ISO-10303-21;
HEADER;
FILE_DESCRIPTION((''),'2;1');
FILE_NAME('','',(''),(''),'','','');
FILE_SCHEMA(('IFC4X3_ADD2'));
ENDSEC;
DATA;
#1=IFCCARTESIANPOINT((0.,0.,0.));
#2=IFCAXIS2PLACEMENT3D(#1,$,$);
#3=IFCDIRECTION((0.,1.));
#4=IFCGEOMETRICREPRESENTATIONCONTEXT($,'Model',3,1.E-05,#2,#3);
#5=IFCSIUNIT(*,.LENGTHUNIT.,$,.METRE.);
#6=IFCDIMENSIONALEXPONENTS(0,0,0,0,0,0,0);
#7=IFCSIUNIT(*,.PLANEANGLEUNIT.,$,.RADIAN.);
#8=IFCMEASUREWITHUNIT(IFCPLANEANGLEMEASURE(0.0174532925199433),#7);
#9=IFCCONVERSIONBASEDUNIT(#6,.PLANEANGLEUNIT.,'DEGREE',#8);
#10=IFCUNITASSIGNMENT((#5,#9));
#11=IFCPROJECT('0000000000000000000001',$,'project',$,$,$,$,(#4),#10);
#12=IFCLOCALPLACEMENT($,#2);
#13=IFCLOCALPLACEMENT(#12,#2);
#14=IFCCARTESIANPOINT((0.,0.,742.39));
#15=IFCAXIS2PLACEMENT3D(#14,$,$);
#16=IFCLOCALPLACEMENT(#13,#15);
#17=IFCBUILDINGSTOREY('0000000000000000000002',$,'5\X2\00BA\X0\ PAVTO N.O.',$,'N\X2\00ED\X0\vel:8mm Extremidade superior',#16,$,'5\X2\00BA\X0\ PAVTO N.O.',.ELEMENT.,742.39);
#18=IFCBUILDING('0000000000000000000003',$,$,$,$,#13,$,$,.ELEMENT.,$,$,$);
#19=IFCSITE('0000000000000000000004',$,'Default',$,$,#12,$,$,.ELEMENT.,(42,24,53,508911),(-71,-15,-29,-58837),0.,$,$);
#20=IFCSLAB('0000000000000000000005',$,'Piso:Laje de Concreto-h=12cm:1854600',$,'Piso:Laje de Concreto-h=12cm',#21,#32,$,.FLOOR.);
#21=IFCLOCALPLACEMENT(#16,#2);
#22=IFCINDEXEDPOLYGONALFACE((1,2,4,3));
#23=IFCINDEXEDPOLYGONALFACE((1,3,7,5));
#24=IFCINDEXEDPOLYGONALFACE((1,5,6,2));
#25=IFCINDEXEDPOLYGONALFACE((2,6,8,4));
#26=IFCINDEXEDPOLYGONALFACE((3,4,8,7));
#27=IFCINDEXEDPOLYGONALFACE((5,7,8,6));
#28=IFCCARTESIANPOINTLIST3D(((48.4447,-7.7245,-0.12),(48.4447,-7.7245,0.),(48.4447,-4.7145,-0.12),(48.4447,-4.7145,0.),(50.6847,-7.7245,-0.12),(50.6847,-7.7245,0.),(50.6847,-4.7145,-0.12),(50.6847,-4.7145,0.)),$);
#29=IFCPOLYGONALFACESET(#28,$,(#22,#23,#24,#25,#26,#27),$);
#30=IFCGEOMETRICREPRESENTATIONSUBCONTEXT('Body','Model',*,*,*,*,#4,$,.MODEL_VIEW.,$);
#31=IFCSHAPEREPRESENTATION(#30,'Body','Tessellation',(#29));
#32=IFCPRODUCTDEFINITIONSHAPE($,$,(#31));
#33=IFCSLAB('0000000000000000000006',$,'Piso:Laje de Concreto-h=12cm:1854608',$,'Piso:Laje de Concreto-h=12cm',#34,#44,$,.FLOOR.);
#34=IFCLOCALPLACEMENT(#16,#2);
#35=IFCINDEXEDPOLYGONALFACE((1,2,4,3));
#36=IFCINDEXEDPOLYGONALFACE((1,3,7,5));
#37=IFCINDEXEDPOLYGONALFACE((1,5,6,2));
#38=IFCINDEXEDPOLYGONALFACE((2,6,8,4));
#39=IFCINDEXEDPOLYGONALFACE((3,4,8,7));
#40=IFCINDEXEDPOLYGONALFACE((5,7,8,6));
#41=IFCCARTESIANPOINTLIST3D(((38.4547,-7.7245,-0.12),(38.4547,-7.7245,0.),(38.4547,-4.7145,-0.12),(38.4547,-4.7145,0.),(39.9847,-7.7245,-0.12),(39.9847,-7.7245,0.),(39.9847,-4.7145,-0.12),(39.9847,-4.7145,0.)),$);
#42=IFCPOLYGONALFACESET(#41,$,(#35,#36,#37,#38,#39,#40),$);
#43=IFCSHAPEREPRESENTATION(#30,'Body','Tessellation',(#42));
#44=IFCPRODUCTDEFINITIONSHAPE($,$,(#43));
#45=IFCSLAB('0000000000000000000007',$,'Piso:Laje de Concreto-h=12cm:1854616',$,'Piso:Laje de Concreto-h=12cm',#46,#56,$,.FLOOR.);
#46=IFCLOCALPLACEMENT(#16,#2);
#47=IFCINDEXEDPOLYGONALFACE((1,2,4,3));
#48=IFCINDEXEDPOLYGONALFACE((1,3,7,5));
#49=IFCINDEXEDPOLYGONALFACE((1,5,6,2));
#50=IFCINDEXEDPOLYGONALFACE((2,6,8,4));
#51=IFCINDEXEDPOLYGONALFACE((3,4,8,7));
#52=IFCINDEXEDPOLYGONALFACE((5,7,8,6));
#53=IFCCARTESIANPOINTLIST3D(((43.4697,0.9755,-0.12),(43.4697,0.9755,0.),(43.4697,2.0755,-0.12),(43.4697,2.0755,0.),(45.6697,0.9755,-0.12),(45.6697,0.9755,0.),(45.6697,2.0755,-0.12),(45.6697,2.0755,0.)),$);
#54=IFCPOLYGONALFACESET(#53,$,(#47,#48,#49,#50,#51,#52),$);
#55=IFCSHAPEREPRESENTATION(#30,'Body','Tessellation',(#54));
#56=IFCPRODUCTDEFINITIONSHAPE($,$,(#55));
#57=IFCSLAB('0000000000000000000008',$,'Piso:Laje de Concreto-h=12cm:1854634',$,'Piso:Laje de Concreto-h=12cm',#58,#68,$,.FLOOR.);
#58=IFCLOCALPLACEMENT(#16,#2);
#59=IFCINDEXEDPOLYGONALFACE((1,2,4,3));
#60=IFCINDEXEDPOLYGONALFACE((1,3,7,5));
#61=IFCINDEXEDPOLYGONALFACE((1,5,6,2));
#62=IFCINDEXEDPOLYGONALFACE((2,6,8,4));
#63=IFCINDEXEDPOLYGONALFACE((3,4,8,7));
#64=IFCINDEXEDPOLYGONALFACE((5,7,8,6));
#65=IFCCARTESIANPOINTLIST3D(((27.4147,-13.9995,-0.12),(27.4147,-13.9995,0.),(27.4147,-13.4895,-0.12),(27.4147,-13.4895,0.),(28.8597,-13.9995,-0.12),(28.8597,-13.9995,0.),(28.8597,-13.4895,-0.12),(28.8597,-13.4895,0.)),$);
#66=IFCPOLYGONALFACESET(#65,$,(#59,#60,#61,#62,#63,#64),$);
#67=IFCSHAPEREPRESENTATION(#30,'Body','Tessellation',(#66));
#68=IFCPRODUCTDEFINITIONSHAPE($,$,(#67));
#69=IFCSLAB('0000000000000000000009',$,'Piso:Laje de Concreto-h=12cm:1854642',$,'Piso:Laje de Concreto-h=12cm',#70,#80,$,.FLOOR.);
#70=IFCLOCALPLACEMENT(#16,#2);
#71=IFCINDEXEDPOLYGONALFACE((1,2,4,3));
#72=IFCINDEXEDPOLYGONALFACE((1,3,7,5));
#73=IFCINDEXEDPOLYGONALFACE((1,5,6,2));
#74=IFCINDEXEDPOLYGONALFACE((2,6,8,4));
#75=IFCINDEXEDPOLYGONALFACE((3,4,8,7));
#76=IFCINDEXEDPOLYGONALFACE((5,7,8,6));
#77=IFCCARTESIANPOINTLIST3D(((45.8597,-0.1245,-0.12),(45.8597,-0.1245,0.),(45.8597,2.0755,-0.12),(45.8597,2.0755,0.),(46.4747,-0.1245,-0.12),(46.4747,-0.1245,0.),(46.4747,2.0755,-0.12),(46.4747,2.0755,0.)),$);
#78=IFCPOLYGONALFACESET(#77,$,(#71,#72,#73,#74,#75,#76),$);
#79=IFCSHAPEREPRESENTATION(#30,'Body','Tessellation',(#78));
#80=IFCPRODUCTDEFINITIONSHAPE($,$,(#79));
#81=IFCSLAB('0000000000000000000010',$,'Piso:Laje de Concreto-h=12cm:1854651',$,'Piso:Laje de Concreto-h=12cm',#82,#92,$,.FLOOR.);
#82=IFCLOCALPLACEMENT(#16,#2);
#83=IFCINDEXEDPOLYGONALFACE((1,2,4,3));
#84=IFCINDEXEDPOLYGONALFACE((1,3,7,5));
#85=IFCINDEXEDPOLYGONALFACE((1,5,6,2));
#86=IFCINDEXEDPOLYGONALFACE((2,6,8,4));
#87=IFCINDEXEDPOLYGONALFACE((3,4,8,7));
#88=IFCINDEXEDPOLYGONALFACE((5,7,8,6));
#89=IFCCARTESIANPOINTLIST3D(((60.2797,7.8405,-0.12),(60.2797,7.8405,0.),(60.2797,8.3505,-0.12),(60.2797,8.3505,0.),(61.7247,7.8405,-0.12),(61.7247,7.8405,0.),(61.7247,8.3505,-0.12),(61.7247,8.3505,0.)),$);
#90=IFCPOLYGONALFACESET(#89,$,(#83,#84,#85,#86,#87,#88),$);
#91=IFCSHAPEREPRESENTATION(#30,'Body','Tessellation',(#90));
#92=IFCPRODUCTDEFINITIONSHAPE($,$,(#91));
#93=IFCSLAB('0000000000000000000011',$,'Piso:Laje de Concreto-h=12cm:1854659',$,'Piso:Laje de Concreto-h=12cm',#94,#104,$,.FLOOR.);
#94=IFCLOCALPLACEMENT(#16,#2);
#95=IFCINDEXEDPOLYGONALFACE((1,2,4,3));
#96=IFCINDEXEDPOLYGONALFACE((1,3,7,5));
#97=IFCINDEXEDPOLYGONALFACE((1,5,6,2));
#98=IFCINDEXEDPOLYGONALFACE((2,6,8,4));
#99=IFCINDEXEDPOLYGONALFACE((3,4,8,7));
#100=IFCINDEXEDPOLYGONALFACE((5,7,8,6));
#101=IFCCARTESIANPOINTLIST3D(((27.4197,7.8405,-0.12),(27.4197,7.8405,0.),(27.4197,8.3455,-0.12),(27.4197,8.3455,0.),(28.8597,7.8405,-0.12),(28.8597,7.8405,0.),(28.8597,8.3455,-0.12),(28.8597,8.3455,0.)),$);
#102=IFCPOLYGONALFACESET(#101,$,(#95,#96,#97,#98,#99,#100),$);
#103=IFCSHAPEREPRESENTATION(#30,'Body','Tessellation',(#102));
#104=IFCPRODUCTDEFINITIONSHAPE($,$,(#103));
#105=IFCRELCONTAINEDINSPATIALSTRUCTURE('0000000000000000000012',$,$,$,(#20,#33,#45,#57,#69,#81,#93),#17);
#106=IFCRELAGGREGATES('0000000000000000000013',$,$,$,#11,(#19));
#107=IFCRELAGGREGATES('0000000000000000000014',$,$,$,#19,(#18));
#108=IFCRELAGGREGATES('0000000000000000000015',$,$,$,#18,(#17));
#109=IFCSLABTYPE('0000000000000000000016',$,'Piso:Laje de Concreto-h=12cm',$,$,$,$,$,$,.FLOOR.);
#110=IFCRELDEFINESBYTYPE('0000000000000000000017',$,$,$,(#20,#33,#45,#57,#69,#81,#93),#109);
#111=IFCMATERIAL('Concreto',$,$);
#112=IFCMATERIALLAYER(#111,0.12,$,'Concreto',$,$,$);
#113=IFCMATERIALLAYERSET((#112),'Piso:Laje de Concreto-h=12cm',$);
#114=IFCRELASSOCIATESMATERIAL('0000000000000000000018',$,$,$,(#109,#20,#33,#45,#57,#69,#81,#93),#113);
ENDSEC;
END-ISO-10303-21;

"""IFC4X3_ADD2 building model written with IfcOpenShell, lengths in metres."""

from ifc_helpers import new_model, entity, si_unit, converted_unit, direction, frame, frame_2d, origin, origin_2d_with_axis, place, context, subcontext, project, spatial, rectangle, extrude, material, layer, layer_set, layer_usage, type_object, element, save


model = new_model("IFC4X3_ADD2")

# Units and contexts
model_context = context("Model", 3, precision=1e-05, world=origin(), true_north=direction((0.0, 1.0)))
body_context = subcontext(model_context, "Body", "Model", "MODEL_VIEW")
ifc_project = project(units=[si_unit("LENGTHUNIT", "METRE"), converted_unit("PLANEANGLEUNIT", "DEGREE", entity("IfcPlaneAngleMeasure", 0.0174532925199433), si_unit("PLANEANGLEUNIT", "RADIAN"), dimensions=[0, 0, 0, 0, 0, 0, 0])], contexts=[model_context])

# Site, building, storey
site_placement = place(None, origin())
site = spatial("IfcSite", under=ifc_project, at=site_placement, Name="Default", CompositionType="ELEMENT", RefLatitude=(42, 24, 53, 508911), RefLongitude=(-71, -15, -29, -58837), RefElevation=0.0)
building_placement = place(site_placement, origin())
building = spatial("IfcBuilding", under=site, at=building_placement, CompositionType="ELEMENT")
storey_placement = place(building_placement, frame((0.0, 0.0, 742.39)))
storey = spatial("IfcBuildingStorey", under=building, at=storey_placement, Name="5º PAVTO N.O.", ObjectType="Nível:8mm Extremidade superior", LongName="5º PAVTO N.O.", CompositionType="ELEMENT", Elevation=742.39)

# Shared definitions
ifc_material = material(Name="Concreto")

# Shared definitions
ifc_layer_1 = layer(ifc_material, 0.12, Name="Concreto")
ifc_layer_set_1 = layer_set([ifc_layer_1], Name="Piso:Laje de Concreto-h=12cm")
slab_type_1 = type_object("IfcSlabType", Name="Piso:Laje de Concreto-h=12cm", PredefinedType="FLOOR", material=ifc_layer_set_1)

# Slabs
ifc_layer_usage_1 = layer_usage(ifc_layer_set_1, "AXIS3", "POSITIVE", 0.0)
slab_1_placement = place(storey_placement, origin())
element("IfcSlab", 1, at=slab_1_placement, inside=storey, type_object=slab_type_1, material=ifc_layer_usage_1, Name="Piso:Laje de Concreto-h=12cm:1854600", ObjectType="Piso:Laje de Concreto-h=12cm", PredefinedType="FLOOR", context=body_context, shape_type="SweptSolid", body=[
    extrude(rectangle(XDim=3.01, YDim=2.24, at=origin_2d_with_axis()), frame((49.5647, -6.2195, 0.0), z_axis=(0.0, 0.0, -1.0), x_axis=(0.0, 1.0, 0.0)), (0.0, 0.0, 1.0), 0.12),
])
ifc_layer_usage_2 = layer_usage(ifc_layer_set_1, "AXIS3", "POSITIVE", 0.0)
slab_2_placement = place(storey_placement, origin())
element("IfcSlab", 2, at=slab_2_placement, inside=storey, type_object=slab_type_1, material=ifc_layer_usage_2, Name="Piso:Laje de Concreto-h=12cm:1854608", ObjectType="Piso:Laje de Concreto-h=12cm", PredefinedType="FLOOR", context=body_context, shape_type="SweptSolid", body=[
    extrude(rectangle(XDim=3.01, YDim=1.53, at=frame_2d((0.0, 0.0), x_axis=(1.0, 0.0))), frame((39.2197, -6.2195, 0.0), z_axis=(0.0, 0.0, -1.0), x_axis=(0.0, 1.0, 0.0)), (0.0, 0.0, 1.0), 0.12),
])
ifc_layer_usage_3 = layer_usage(ifc_layer_set_1, "AXIS3", "POSITIVE", 0.0)
slab_3_placement = place(storey_placement, origin())
element("IfcSlab", 3, at=slab_3_placement, inside=storey, type_object=slab_type_1, material=ifc_layer_usage_3, Name="Piso:Laje de Concreto-h=12cm:1854616", ObjectType="Piso:Laje de Concreto-h=12cm", PredefinedType="FLOOR", context=body_context, shape_type="SweptSolid", body=[
    extrude(rectangle(XDim=1.1, YDim=2.2, at=frame_2d((0.0, 0.0), x_axis=(1.0, 0.0))), frame((44.5697, 1.5255, 0.0), z_axis=(0.0, 0.0, -1.0), x_axis=(0.0, 1.0, 0.0)), (0.0, 0.0, 1.0), 0.12),
])
ifc_layer_usage_4 = layer_usage(ifc_layer_set_1, "AXIS3", "POSITIVE", 0.0)
slab_4_placement = place(storey_placement, origin())
element("IfcSlab", 4, at=slab_4_placement, inside=storey, type_object=slab_type_1, material=ifc_layer_usage_4, Name="Piso:Laje de Concreto-h=12cm:1854634", ObjectType="Piso:Laje de Concreto-h=12cm", PredefinedType="FLOOR", context=body_context, shape_type="SweptSolid", body=[
    extrude(rectangle(XDim=0.51, YDim=1.445, at=frame_2d((0.0, 0.0), x_axis=(1.0, 0.0))), frame((28.1372, -13.7445, 0.0), z_axis=(0.0, 0.0, -1.0), x_axis=(0.0, 1.0, 0.0)), (0.0, 0.0, 1.0), 0.12),
])
ifc_layer_usage_5 = layer_usage(ifc_layer_set_1, "AXIS3", "POSITIVE", 0.0)
slab_5_placement = place(storey_placement, origin())
element("IfcSlab", 5, at=slab_5_placement, inside=storey, type_object=slab_type_1, material=ifc_layer_usage_5, Name="Piso:Laje de Concreto-h=12cm:1854642", ObjectType="Piso:Laje de Concreto-h=12cm", PredefinedType="FLOOR", context=body_context, shape_type="SweptSolid", body=[
    extrude(rectangle(XDim=2.2, YDim=0.615, at=frame_2d((0.0, 0.0), x_axis=(1.0, 0.0))), frame((46.1672, 0.9755, 0.0), z_axis=(0.0, 0.0, -1.0), x_axis=(0.0, 1.0, 0.0)), (0.0, 0.0, 1.0), 0.12),
])
ifc_layer_usage_6 = layer_usage(ifc_layer_set_1, "AXIS3", "POSITIVE", 0.0)
slab_6_placement = place(storey_placement, origin())
element("IfcSlab", 6, at=slab_6_placement, inside=storey, type_object=slab_type_1, material=ifc_layer_usage_6, Name="Piso:Laje de Concreto-h=12cm:1854651", ObjectType="Piso:Laje de Concreto-h=12cm", PredefinedType="FLOOR", context=body_context, shape_type="SweptSolid", body=[
    extrude(rectangle(XDim=0.51, YDim=1.445, at=frame_2d((0.0, 0.0), x_axis=(1.0, 0.0))), frame((61.0022, 8.0955, 0.0), z_axis=(0.0, 0.0, -1.0), x_axis=(0.0, 1.0, 0.0)), (0.0, 0.0, 1.0), 0.12),
])
ifc_layer_usage_7 = layer_usage(ifc_layer_set_1, "AXIS3", "POSITIVE", 0.0)
slab_7_placement = place(storey_placement, origin())
element("IfcSlab", 7, at=slab_7_placement, inside=storey, type_object=slab_type_1, material=ifc_layer_usage_7, Name="Piso:Laje de Concreto-h=12cm:1854659", ObjectType="Piso:Laje de Concreto-h=12cm", PredefinedType="FLOOR", context=body_context, shape_type="SweptSolid", body=[
    extrude(rectangle(XDim=0.505, YDim=1.44, at=origin_2d_with_axis()), frame((28.1397, 8.093, 0.0), z_axis=(0.0, 0.0, -1.0), x_axis=(0.0, 1.0, 0.0)), (0.0, 0.0, 1.0), 0.12),
])

save(model, "model.ifc")
